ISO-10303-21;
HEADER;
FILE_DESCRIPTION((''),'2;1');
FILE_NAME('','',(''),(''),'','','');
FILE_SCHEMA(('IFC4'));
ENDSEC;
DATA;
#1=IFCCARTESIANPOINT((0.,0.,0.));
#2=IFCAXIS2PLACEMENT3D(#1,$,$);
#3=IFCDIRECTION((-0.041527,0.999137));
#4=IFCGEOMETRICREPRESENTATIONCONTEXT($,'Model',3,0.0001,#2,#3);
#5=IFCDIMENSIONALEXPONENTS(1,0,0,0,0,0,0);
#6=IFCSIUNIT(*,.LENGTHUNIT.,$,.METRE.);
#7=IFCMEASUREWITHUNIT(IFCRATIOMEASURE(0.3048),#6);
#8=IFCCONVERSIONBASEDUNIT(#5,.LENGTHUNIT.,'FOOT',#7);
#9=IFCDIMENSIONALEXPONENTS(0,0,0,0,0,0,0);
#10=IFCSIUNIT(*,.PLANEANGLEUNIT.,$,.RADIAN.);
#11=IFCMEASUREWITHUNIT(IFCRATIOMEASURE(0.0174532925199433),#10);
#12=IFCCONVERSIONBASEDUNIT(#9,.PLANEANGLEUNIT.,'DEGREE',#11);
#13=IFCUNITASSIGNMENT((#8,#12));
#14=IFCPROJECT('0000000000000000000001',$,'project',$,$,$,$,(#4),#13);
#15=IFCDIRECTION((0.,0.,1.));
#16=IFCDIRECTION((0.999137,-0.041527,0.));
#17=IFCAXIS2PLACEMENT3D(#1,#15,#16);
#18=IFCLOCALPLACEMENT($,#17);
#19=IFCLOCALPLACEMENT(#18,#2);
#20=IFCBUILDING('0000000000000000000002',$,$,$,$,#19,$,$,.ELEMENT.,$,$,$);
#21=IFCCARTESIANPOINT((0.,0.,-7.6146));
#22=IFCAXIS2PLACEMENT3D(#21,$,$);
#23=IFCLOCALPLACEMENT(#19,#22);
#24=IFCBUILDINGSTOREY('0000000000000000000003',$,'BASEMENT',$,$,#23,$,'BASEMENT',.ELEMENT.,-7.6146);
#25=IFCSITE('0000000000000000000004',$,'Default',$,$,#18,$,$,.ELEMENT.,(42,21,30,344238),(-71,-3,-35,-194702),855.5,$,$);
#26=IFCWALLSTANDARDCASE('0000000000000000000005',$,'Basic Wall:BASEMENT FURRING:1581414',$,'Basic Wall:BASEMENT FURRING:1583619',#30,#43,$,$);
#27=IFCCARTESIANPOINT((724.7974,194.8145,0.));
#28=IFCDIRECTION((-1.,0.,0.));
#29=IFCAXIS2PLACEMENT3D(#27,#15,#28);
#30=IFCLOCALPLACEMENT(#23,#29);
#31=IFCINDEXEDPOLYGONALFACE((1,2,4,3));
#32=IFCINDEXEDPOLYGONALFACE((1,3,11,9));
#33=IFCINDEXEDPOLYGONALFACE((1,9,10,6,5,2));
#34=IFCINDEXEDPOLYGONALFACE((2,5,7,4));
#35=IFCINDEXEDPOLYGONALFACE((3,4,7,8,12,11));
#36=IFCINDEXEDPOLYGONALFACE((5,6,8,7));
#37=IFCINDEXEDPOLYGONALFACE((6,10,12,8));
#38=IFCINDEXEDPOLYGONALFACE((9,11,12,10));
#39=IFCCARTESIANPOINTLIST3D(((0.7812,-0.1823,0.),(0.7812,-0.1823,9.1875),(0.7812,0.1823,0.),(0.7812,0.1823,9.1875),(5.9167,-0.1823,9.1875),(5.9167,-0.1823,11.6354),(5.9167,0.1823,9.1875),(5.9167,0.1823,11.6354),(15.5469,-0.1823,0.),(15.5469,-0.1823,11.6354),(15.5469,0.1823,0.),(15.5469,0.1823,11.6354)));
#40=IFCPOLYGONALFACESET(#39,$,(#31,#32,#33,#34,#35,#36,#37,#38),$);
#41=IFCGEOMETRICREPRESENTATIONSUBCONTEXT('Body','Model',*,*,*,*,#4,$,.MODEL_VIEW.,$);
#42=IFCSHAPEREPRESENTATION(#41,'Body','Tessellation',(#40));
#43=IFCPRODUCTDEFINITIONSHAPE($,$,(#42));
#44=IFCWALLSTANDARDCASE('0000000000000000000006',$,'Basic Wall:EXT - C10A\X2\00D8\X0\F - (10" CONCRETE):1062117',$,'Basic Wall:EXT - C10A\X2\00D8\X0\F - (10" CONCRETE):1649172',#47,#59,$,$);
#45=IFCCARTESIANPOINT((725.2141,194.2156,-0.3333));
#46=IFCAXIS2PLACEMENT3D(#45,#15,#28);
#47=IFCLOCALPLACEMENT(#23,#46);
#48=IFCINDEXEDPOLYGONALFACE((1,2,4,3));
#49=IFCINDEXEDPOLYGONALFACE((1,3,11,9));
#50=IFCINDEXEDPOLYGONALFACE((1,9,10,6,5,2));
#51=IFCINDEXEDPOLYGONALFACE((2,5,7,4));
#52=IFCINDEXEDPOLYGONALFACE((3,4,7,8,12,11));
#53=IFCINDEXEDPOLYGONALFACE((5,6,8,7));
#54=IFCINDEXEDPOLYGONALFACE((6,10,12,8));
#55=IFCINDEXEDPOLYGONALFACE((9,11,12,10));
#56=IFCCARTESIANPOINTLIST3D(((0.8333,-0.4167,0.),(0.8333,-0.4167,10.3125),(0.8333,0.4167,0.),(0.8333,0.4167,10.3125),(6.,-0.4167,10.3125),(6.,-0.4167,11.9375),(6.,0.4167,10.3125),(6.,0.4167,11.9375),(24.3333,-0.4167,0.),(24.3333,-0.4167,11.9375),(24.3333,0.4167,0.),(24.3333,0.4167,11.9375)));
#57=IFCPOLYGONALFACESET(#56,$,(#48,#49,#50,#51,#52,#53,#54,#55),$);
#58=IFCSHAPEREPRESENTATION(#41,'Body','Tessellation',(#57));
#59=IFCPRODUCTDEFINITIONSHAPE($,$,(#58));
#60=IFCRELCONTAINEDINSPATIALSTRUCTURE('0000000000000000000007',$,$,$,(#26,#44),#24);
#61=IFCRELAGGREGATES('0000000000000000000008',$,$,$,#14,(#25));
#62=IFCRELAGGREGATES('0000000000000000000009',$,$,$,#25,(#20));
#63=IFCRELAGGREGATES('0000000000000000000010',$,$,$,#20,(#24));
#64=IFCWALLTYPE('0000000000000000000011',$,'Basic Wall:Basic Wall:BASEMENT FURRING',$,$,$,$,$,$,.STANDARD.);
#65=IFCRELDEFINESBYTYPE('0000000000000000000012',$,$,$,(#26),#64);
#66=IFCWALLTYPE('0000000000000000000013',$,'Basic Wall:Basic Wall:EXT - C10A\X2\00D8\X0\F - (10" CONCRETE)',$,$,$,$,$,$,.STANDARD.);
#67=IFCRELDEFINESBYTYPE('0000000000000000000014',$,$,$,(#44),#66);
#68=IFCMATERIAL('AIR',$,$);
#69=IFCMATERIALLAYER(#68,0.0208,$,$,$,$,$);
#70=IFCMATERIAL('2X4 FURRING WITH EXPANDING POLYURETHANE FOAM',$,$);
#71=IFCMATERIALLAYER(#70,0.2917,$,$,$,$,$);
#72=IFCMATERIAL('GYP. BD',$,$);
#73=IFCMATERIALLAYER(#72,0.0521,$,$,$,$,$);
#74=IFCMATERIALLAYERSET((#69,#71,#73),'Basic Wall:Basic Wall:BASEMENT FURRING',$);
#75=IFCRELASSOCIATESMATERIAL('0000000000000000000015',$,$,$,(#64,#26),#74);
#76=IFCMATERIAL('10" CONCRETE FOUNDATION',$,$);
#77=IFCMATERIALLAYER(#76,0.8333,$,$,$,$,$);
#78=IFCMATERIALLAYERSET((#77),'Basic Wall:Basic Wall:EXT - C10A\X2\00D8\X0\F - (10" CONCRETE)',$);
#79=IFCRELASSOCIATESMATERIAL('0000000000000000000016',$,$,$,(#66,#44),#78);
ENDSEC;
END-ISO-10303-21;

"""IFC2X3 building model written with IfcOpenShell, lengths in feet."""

from ifc_helpers import new_model, entity, si_unit, converted_unit, direction, frame, frame_2d, origin, origin_2d_with_axis, place, context, subcontext, project, spatial, rectangle, extrude, material, layer, layer_set, layer_usage, type_object, element, save


model = new_model("IFC2X3")

# Units and contexts
model_context = context("Model", 3, precision=0.0001, world=origin(), true_north=direction((-0.041527, 0.999137)))
body_context = subcontext(model_context, "Body", "Model", "MODEL_VIEW")
ifc_project = project(units=[converted_unit("LENGTHUNIT", "FOOT", entity("IfcRatioMeasure", 0.3048), si_unit("LENGTHUNIT", "METRE"), dimensions=[1, 0, 0, 0, 0, 0, 0]), converted_unit("PLANEANGLEUNIT", "DEGREE", entity("IfcRatioMeasure", 0.0174532925199433), si_unit("PLANEANGLEUNIT", "RADIAN"), dimensions=[0, 0, 0, 0, 0, 0, 0])], contexts=[model_context])

# Site, building, storey
site_placement = place(None, frame((0.0, 0.0, 0.0), z_axis=(0.0, 0.0, 1.0), x_axis=(0.999137, -0.041527, 0.0)))
site = spatial("IfcSite", under=ifc_project, at=site_placement, Name="Default", CompositionType="ELEMENT", RefLatitude=(42, 21, 30, 344238), RefLongitude=(-71, -3, -35, -194702), RefElevation=855.5)
building_placement = place(site_placement, origin())
building = spatial("IfcBuilding", under=site, at=building_placement, CompositionType="ELEMENT")
storey_placement = place(building_placement, frame((0.0, 0.0, -7.6146)))
storey = spatial("IfcBuildingStorey", under=building, at=storey_placement, Name="BASEMENT", LongName="BASEMENT", CompositionType="ELEMENT", Elevation=-7.6146)

# Wall, opening
ifc_material_1 = material(Name="AIR")
ifc_layer_1 = layer(ifc_material_1, 0.0208)
ifc_material_2 = material(Name="2X4 FURRING WITH EXPANDING POLYURETHANE FOAM")
ifc_layer_2 = layer(ifc_material_2, 0.2917)
ifc_material_3 = material(Name="GYP. BD")
ifc_layer_3 = layer(ifc_material_3, 0.0521)
ifc_layer_set_1 = layer_set([ifc_layer_1, ifc_layer_2, ifc_layer_3], Name="Basic Wall:Basic Wall:BASEMENT FURRING")
ifc_layer_usage_1 = layer_usage(ifc_layer_set_1, "AXIS2", "NEGATIVE", 0.1823)
wall_type_1 = type_object("IfcWallType", Name="Basic Wall:Basic Wall:BASEMENT FURRING", PredefinedType="STANDARD", material=ifc_layer_set_1)
wall_1_placement = place(storey_placement, frame((724.7974, 194.8145, 0.0), z_axis=(0.0, 0.0, 1.0), x_axis=(-1.0, 0.0, 0.0)))
wall_1 = element("IfcWallStandardCase", 1, at=wall_1_placement, inside=storey, type_object=wall_type_1, material=ifc_layer_usage_1, Name="Basic Wall:BASEMENT FURRING:1581414", ObjectType="Basic Wall:BASEMENT FURRING:1583619", context=body_context, shape_type="SweptSolid", body=[
    extrude(rectangle(XDim=14.7656, YDim=0.3646, at=frame_2d((8.1641, 0.0), x_axis=(-1.0, 0.0))), origin(), (0.0, 0.0, 1.0), 11.6354),
])
opening_1_placement = place(wall_1_placement, origin())
element("IfcOpeningElement", 2, at=opening_1_placement, cuts=wall_1, ObjectType="Opening", context=body_context, shape_type="SweptSolid", body=[
    extrude(rectangle(XDim=2.4479, YDim=5.3177, at=origin_2d_with_axis()), frame((3.2578, -0.1823, 10.4115), z_axis=(0.0, 1.0, 0.0), x_axis=(0.0, 0.0, -1.0)), (0.0, 0.0, 1.0), 0.3646),
])

# Wall, opening
ifc_material_4 = material(Name="10\" CONCRETE FOUNDATION")
ifc_layer_4 = layer(ifc_material_4, 0.8333)
ifc_layer_set_2 = layer_set([ifc_layer_4], Name="Basic Wall:Basic Wall:EXT - C10AØF - (10\" CONCRETE)")
ifc_layer_usage_2 = layer_usage(ifc_layer_set_2, "AXIS2", "NEGATIVE", 0.4167)
wall_type_2 = type_object("IfcWallType", Name="Basic Wall:Basic Wall:EXT - C10AØF - (10\" CONCRETE)", PredefinedType="STANDARD", material=ifc_layer_set_2)
wall_2_placement = place(storey_placement, frame((725.2141, 194.2156, -0.3333), z_axis=(0.0, 0.0, 1.0), x_axis=(-1.0, 0.0, 0.0)))
wall_2 = element("IfcWallStandardCase", 3, at=wall_2_placement, inside=storey, type_object=wall_type_2, material=ifc_layer_usage_2, Name="Basic Wall:EXT - C10AØF - (10\" CONCRETE):1062117", ObjectType="Basic Wall:EXT - C10AØF - (10\" CONCRETE):1649172", context=body_context, shape_type="SweptSolid", body=[
    extrude(rectangle(XDim=23.5, YDim=0.8333, at=frame_2d((12.5833, 0.0), x_axis=(-1.0, 0.0))), origin(), (0.0, 0.0, 1.0), 11.9375),
])
opening_2_placement = place(wall_2_placement, origin())
element("IfcOpeningElement", 4, at=opening_2_placement, cuts=wall_2, ObjectType="Opening", context=body_context, shape_type="SweptSolid", body=[
    extrude(rectangle(XDim=1.625, YDim=5.5833, at=frame_2d((0.0, 0.0), x_axis=(1.0, 0.0))), frame((3.2083, -0.4167, 11.125), z_axis=(0.0, 1.0, 0.0), x_axis=(0.0, 0.0, -1.0)), (0.0, 0.0, 1.0), 0.8333),
])

save(model, "model.ifc")
